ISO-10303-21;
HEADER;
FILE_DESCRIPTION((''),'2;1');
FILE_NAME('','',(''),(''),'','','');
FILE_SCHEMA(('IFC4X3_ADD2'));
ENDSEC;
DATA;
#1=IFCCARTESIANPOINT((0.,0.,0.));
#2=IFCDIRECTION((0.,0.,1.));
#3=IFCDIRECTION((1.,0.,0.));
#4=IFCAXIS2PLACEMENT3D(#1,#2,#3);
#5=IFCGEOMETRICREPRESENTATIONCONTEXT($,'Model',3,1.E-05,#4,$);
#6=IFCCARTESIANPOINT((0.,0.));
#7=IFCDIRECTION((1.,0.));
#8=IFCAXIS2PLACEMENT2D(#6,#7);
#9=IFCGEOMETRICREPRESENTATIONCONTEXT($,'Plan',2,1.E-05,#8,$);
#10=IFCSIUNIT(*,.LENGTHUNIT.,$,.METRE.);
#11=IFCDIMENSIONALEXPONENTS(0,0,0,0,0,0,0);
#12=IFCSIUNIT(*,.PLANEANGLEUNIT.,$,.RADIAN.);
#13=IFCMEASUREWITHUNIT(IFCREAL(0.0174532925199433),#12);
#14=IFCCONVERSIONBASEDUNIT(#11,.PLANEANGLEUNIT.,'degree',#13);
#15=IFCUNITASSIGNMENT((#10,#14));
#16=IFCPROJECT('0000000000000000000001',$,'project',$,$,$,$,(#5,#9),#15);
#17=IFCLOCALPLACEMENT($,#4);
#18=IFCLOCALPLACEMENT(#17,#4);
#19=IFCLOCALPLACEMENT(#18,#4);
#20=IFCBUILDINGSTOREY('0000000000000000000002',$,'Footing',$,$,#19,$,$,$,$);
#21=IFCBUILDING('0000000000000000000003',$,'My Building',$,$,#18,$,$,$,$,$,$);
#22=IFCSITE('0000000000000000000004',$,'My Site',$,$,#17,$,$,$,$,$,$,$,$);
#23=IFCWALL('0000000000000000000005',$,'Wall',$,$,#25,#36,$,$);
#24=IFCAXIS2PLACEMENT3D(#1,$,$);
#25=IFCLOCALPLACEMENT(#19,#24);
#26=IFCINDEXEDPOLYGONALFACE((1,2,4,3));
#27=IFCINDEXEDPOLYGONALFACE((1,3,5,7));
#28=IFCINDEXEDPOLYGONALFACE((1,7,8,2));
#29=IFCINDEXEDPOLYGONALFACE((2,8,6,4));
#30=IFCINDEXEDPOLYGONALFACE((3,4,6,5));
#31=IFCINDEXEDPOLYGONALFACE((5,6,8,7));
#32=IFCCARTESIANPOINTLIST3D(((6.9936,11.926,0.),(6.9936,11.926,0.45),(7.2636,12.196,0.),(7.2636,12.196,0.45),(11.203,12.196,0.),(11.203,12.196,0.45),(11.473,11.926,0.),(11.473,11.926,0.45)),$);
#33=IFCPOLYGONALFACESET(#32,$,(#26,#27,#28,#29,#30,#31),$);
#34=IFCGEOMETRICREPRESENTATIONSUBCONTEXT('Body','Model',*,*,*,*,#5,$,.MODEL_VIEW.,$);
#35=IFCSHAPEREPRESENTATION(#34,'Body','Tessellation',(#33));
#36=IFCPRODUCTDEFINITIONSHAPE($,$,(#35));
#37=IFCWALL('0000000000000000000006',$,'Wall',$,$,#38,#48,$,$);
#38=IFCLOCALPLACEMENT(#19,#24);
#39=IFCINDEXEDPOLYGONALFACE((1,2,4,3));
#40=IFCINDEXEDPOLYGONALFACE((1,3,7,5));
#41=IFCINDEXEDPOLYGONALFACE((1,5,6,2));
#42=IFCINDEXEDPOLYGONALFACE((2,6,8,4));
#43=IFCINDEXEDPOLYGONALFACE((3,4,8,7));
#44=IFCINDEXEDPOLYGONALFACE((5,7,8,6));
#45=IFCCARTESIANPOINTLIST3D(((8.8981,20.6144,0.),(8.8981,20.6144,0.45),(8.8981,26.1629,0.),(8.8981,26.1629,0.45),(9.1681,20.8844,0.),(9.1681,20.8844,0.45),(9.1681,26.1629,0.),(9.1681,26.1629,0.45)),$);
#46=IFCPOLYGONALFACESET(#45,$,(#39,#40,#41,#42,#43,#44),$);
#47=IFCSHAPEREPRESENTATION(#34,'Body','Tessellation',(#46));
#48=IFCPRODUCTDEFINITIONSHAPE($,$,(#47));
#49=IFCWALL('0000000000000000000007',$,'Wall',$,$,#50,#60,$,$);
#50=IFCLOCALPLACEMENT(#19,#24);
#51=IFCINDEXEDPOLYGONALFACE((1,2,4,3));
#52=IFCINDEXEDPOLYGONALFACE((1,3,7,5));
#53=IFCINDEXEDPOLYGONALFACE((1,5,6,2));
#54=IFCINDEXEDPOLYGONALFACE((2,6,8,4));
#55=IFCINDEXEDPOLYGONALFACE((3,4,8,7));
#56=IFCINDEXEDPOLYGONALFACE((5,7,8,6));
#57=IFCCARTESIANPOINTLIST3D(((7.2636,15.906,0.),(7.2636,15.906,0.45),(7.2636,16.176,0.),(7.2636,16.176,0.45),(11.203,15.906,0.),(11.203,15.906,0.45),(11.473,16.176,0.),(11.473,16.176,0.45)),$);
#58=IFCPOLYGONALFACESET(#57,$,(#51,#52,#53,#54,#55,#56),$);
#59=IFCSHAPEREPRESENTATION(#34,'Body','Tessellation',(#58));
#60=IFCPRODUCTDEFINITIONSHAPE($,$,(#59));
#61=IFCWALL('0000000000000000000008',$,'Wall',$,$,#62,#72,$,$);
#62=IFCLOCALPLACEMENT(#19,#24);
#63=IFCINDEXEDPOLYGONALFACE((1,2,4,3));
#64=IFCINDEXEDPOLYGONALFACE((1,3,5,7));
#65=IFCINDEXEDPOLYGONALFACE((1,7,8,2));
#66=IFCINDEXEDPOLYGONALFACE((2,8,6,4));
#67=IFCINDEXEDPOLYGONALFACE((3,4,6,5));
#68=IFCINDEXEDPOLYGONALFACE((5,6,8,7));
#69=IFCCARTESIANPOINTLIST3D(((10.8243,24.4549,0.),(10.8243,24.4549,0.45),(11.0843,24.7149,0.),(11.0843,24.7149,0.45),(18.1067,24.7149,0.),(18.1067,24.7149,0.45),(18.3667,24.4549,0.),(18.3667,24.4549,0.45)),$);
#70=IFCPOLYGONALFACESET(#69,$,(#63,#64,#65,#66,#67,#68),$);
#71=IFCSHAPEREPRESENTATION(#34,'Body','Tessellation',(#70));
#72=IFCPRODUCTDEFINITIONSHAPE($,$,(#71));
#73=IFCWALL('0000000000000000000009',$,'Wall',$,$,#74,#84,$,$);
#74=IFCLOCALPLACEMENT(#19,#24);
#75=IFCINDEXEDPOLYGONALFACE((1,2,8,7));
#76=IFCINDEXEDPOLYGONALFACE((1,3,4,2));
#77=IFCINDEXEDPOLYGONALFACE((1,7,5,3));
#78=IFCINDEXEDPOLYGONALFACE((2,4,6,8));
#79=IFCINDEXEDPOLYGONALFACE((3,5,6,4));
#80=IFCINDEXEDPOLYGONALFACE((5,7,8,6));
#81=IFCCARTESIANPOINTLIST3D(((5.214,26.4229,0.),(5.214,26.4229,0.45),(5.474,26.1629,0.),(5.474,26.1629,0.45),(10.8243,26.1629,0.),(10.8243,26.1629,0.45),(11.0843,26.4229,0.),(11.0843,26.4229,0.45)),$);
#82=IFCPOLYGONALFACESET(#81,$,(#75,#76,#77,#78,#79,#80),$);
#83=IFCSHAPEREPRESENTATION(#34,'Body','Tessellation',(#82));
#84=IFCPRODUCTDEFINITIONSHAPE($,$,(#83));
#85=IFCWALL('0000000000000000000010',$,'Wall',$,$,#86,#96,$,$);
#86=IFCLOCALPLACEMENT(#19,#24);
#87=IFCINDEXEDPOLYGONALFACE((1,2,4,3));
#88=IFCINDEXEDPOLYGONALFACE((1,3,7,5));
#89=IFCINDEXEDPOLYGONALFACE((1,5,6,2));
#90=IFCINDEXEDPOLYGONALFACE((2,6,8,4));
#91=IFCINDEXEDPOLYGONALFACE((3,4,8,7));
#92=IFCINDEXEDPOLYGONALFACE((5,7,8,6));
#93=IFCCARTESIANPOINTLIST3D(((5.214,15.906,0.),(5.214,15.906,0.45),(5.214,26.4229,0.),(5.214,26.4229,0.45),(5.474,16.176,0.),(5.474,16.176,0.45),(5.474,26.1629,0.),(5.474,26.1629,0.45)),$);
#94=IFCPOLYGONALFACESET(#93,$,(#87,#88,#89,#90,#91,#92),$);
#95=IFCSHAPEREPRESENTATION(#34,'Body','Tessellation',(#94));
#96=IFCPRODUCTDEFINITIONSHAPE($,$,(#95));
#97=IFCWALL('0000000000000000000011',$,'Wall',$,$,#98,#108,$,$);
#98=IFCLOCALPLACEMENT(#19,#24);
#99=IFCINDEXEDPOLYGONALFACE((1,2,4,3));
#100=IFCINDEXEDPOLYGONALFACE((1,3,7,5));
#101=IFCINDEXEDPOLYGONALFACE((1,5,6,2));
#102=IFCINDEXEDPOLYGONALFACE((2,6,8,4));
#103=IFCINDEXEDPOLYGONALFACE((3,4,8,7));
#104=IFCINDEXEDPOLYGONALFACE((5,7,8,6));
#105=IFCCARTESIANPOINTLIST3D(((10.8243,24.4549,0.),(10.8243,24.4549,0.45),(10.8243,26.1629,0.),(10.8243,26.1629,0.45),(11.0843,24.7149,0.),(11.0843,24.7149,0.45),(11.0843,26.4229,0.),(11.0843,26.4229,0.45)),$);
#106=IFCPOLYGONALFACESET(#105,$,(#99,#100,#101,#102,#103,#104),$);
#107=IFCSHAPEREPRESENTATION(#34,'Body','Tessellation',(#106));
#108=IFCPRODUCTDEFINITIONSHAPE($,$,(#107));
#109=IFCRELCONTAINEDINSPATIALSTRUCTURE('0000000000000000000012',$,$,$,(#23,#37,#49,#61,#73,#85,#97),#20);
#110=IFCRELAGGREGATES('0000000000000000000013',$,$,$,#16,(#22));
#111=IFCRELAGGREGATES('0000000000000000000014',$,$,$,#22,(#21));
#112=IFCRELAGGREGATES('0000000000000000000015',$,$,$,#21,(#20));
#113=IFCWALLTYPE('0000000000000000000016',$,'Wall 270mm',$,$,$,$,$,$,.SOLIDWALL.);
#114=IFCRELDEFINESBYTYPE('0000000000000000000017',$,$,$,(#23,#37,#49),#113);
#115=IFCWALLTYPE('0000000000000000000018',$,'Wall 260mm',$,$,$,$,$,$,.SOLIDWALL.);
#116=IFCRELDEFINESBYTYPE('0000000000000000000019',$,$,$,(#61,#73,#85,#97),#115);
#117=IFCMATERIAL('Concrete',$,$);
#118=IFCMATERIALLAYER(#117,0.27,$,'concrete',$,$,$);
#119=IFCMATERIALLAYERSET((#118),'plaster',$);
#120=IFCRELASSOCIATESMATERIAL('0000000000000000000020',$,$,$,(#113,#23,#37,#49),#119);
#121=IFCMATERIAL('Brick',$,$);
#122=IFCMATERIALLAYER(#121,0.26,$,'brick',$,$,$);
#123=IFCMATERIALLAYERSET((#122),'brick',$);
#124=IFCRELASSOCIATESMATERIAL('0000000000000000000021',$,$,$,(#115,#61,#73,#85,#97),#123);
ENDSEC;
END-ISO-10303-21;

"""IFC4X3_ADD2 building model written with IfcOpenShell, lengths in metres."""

from ifc_helpers import new_model, entity, si_unit, converted_unit, frame, origin_with_axes, origin_2d_with_axis, place, context, subcontext, project, spatial, line, indexed_curve, outline, extrude, material, layer, layer_set, layer_usage, type_object, element, save


model = new_model("IFC4X3_ADD2")

# Units and contexts
model_context = context("Model", 3, precision=1e-05, world=origin_with_axes())
plan_context = context("Plan", 2, precision=1e-05, world=origin_2d_with_axis())
body_context = subcontext(model_context, "Body", "Model", "MODEL_VIEW")
ifc_project = project(units=[si_unit("LENGTHUNIT", "METRE"), converted_unit("PLANEANGLEUNIT", "degree", entity("IfcReal", 0.0174532925199433), si_unit("PLANEANGLEUNIT", "RADIAN"), dimensions=[0, 0, 0, 0, 0, 0, 0])], contexts=[model_context, plan_context])

# Site, building, storey
site_placement = place(None, origin_with_axes())
site = spatial("IfcSite", under=ifc_project, at=site_placement, Name="My Site")
building_placement = place(site_placement, origin_with_axes())
building = spatial("IfcBuilding", under=site, at=building_placement, Name="My Building")
storey_placement = place(building_placement, origin_with_axes())
storey = spatial("IfcBuildingStorey", under=building, at=storey_placement, Name="Footing")

# Shared definitions
ifc_material_1 = material(Name="Brick")

# Walls
ifc_material_2 = material(Name="Concrete")
ifc_layer_1 = layer(ifc_material_2, 0.27, Name="concrete")
ifc_layer_set_1 = layer_set([ifc_layer_1], Name="plaster")
wall_type_1 = type_object("IfcWallType", Name="Wall 270mm", PredefinedType="SOLIDWALL", material=ifc_layer_set_1)
ifc_layer_usage_1 = layer_usage(ifc_layer_set_1, "AXIS2", "POSITIVE", 0.0)
wall_1_placement = place(storey_placement, frame((7.2636, 11.926, 0.0), z_axis=(0.0, 0.0, 1.0), x_axis=(1.0, 0.0, 0.0)))
element("IfcWall", 1, at=wall_1_placement, inside=storey, type_object=wall_type_1, material=ifc_layer_usage_1, Name="Wall", context=body_context, shape_type="SweptSolid", body=[
    extrude(outline(indexed_curve([(-0.27, 0.0), (0.0, 0.27), (3.9394, 0.27), (4.2094, 0.0)], segments=[line(1, 2, 3, 4, 1)])), origin_with_axes(), (0.0, 0.0, 1.0), 0.45),
])
ifc_layer_usage_2 = layer_usage(ifc_layer_set_1, "AXIS2", "POSITIVE", 0.0)
wall_2_placement = place(storey_placement, frame((9.1681, 20.6144, 0.0), z_axis=(0.0, 0.0, 1.0), x_axis=(0.0, 1.0, 0.0)))
element("IfcWall", 2, at=wall_2_placement, inside=storey, type_object=wall_type_1, material=ifc_layer_usage_2, Name="Wall", context=body_context, shape_type="SweptSolid", body=[
    extrude(outline(indexed_curve([(0.27, 0.0), (0.0, 0.27), (5.5485, 0.27), (5.5485, 0.0)], segments=[line(1, 2, 3, 4, 1)])), origin_with_axes(), (0.0, 0.0, 1.0), 0.45),
])
ifc_layer_usage_3 = layer_usage(ifc_layer_set_1, "AXIS2", "POSITIVE", 0.0)
wall_3_placement = place(storey_placement, frame((7.2636, 15.906, 0.0), z_axis=(0.0, 0.0, 1.0), x_axis=(1.0, 0.0, 0.0)))
element("IfcWall", 3, at=wall_3_placement, inside=storey, type_object=wall_type_1, material=ifc_layer_usage_3, Name="Wall", context=body_context, shape_type="SweptSolid", body=[
    extrude(outline(indexed_curve([(0.0, 0.0), (0.0, 0.27), (4.2094, 0.27), (3.9394, 0.0)], segments=[line(1, 2, 3, 4, 1)])), origin_with_axes(), (0.0, 0.0, 1.0), 0.45),
])
ifc_layer_2 = layer(ifc_material_1, 0.26, Name="brick")
ifc_layer_set_2 = layer_set([ifc_layer_2], Name="brick")
ifc_layer_usage_4 = layer_usage(ifc_layer_set_2, "AXIS2", "POSITIVE", 0.0)
wall_type_2 = type_object("IfcWallType", Name="Wall 260mm", PredefinedType="SOLIDWALL", material=ifc_layer_set_2)
wall_4_placement = place(storey_placement, frame((11.0843, 24.4549, 0.0), z_axis=(0.0, 0.0, 1.0), x_axis=(1.0, 0.0, 0.0)))
element("IfcWall", 4, at=wall_4_placement, inside=storey, type_object=wall_type_2, material=ifc_layer_usage_4, Name="Wall", context=body_context, shape_type="SweptSolid", body=[
    extrude(outline(indexed_curve([(-0.26, 0.0), (0.0, 0.26), (7.0224, 0.26), (7.2824, 0.0)], segments=[line(1, 2, 3, 4, 1)])), origin_with_axes(), (0.0, 0.0, 1.0), 0.45),
])
ifc_layer_usage_5 = layer_usage(ifc_layer_set_2, "AXIS2", "POSITIVE", 0.0)
wall_5_placement = place(storey_placement, frame((5.474, 26.1629, 0.0), z_axis=(0.0, 0.0, 1.0), x_axis=(1.0, 0.0, 0.0)))
element("IfcWall", 5, at=wall_5_placement, inside=storey, type_object=wall_type_2, material=ifc_layer_usage_5, Name="Wall", context=body_context, shape_type="SweptSolid", body=[
    extrude(outline(indexed_curve([(0.0, 0.0), (-0.26, 0.26), (5.6103, 0.26), (5.3503, 0.0)], segments=[line(1, 2, 3, 4, 1)])), origin_with_axes(), (0.0, 0.0, 1.0), 0.45),
])
ifc_layer_usage_6 = layer_usage(ifc_layer_set_2, "AXIS2", "POSITIVE", 0.0)
wall_6_placement = place(storey_placement, frame((5.474, 15.906, 0.0), z_axis=(0.0, 0.0, 1.0), x_axis=(0.0, 1.0, 0.0)))
element("IfcWall", 6, at=wall_6_placement, inside=storey, type_object=wall_type_2, material=ifc_layer_usage_6, Name="Wall", context=body_context, shape_type="SweptSolid", body=[
    extrude(outline(indexed_curve([(0.27, 0.0), (0.0, 0.26), (10.5169, 0.26), (10.2569, 0.0)], segments=[line(1, 2, 3, 4, 1)])), origin_with_axes(), (0.0, 0.0, 1.0), 0.45),
])
ifc_layer_usage_7 = layer_usage(ifc_layer_set_2, "AXIS2", "POSITIVE", 0.0)
wall_7_placement = place(storey_placement, frame((11.0843, 24.4549, 0.0), z_axis=(0.0, 0.0, 1.0), x_axis=(0.0, 1.0, 0.0)))
element("IfcWall", 7, at=wall_7_placement, inside=storey, type_object=wall_type_2, material=ifc_layer_usage_7, Name="Wall", context=body_context, shape_type="SweptSolid", body=[
    extrude(outline(indexed_curve([(0.26, 0.0), (0.0, 0.26), (1.708, 0.26), (1.968, 0.0)], segments=[line(1, 2, 3, 4, 1)])), origin_with_axes(), (0.0, 0.0, 1.0), 0.45),
])

save(model, "model.ifc")
